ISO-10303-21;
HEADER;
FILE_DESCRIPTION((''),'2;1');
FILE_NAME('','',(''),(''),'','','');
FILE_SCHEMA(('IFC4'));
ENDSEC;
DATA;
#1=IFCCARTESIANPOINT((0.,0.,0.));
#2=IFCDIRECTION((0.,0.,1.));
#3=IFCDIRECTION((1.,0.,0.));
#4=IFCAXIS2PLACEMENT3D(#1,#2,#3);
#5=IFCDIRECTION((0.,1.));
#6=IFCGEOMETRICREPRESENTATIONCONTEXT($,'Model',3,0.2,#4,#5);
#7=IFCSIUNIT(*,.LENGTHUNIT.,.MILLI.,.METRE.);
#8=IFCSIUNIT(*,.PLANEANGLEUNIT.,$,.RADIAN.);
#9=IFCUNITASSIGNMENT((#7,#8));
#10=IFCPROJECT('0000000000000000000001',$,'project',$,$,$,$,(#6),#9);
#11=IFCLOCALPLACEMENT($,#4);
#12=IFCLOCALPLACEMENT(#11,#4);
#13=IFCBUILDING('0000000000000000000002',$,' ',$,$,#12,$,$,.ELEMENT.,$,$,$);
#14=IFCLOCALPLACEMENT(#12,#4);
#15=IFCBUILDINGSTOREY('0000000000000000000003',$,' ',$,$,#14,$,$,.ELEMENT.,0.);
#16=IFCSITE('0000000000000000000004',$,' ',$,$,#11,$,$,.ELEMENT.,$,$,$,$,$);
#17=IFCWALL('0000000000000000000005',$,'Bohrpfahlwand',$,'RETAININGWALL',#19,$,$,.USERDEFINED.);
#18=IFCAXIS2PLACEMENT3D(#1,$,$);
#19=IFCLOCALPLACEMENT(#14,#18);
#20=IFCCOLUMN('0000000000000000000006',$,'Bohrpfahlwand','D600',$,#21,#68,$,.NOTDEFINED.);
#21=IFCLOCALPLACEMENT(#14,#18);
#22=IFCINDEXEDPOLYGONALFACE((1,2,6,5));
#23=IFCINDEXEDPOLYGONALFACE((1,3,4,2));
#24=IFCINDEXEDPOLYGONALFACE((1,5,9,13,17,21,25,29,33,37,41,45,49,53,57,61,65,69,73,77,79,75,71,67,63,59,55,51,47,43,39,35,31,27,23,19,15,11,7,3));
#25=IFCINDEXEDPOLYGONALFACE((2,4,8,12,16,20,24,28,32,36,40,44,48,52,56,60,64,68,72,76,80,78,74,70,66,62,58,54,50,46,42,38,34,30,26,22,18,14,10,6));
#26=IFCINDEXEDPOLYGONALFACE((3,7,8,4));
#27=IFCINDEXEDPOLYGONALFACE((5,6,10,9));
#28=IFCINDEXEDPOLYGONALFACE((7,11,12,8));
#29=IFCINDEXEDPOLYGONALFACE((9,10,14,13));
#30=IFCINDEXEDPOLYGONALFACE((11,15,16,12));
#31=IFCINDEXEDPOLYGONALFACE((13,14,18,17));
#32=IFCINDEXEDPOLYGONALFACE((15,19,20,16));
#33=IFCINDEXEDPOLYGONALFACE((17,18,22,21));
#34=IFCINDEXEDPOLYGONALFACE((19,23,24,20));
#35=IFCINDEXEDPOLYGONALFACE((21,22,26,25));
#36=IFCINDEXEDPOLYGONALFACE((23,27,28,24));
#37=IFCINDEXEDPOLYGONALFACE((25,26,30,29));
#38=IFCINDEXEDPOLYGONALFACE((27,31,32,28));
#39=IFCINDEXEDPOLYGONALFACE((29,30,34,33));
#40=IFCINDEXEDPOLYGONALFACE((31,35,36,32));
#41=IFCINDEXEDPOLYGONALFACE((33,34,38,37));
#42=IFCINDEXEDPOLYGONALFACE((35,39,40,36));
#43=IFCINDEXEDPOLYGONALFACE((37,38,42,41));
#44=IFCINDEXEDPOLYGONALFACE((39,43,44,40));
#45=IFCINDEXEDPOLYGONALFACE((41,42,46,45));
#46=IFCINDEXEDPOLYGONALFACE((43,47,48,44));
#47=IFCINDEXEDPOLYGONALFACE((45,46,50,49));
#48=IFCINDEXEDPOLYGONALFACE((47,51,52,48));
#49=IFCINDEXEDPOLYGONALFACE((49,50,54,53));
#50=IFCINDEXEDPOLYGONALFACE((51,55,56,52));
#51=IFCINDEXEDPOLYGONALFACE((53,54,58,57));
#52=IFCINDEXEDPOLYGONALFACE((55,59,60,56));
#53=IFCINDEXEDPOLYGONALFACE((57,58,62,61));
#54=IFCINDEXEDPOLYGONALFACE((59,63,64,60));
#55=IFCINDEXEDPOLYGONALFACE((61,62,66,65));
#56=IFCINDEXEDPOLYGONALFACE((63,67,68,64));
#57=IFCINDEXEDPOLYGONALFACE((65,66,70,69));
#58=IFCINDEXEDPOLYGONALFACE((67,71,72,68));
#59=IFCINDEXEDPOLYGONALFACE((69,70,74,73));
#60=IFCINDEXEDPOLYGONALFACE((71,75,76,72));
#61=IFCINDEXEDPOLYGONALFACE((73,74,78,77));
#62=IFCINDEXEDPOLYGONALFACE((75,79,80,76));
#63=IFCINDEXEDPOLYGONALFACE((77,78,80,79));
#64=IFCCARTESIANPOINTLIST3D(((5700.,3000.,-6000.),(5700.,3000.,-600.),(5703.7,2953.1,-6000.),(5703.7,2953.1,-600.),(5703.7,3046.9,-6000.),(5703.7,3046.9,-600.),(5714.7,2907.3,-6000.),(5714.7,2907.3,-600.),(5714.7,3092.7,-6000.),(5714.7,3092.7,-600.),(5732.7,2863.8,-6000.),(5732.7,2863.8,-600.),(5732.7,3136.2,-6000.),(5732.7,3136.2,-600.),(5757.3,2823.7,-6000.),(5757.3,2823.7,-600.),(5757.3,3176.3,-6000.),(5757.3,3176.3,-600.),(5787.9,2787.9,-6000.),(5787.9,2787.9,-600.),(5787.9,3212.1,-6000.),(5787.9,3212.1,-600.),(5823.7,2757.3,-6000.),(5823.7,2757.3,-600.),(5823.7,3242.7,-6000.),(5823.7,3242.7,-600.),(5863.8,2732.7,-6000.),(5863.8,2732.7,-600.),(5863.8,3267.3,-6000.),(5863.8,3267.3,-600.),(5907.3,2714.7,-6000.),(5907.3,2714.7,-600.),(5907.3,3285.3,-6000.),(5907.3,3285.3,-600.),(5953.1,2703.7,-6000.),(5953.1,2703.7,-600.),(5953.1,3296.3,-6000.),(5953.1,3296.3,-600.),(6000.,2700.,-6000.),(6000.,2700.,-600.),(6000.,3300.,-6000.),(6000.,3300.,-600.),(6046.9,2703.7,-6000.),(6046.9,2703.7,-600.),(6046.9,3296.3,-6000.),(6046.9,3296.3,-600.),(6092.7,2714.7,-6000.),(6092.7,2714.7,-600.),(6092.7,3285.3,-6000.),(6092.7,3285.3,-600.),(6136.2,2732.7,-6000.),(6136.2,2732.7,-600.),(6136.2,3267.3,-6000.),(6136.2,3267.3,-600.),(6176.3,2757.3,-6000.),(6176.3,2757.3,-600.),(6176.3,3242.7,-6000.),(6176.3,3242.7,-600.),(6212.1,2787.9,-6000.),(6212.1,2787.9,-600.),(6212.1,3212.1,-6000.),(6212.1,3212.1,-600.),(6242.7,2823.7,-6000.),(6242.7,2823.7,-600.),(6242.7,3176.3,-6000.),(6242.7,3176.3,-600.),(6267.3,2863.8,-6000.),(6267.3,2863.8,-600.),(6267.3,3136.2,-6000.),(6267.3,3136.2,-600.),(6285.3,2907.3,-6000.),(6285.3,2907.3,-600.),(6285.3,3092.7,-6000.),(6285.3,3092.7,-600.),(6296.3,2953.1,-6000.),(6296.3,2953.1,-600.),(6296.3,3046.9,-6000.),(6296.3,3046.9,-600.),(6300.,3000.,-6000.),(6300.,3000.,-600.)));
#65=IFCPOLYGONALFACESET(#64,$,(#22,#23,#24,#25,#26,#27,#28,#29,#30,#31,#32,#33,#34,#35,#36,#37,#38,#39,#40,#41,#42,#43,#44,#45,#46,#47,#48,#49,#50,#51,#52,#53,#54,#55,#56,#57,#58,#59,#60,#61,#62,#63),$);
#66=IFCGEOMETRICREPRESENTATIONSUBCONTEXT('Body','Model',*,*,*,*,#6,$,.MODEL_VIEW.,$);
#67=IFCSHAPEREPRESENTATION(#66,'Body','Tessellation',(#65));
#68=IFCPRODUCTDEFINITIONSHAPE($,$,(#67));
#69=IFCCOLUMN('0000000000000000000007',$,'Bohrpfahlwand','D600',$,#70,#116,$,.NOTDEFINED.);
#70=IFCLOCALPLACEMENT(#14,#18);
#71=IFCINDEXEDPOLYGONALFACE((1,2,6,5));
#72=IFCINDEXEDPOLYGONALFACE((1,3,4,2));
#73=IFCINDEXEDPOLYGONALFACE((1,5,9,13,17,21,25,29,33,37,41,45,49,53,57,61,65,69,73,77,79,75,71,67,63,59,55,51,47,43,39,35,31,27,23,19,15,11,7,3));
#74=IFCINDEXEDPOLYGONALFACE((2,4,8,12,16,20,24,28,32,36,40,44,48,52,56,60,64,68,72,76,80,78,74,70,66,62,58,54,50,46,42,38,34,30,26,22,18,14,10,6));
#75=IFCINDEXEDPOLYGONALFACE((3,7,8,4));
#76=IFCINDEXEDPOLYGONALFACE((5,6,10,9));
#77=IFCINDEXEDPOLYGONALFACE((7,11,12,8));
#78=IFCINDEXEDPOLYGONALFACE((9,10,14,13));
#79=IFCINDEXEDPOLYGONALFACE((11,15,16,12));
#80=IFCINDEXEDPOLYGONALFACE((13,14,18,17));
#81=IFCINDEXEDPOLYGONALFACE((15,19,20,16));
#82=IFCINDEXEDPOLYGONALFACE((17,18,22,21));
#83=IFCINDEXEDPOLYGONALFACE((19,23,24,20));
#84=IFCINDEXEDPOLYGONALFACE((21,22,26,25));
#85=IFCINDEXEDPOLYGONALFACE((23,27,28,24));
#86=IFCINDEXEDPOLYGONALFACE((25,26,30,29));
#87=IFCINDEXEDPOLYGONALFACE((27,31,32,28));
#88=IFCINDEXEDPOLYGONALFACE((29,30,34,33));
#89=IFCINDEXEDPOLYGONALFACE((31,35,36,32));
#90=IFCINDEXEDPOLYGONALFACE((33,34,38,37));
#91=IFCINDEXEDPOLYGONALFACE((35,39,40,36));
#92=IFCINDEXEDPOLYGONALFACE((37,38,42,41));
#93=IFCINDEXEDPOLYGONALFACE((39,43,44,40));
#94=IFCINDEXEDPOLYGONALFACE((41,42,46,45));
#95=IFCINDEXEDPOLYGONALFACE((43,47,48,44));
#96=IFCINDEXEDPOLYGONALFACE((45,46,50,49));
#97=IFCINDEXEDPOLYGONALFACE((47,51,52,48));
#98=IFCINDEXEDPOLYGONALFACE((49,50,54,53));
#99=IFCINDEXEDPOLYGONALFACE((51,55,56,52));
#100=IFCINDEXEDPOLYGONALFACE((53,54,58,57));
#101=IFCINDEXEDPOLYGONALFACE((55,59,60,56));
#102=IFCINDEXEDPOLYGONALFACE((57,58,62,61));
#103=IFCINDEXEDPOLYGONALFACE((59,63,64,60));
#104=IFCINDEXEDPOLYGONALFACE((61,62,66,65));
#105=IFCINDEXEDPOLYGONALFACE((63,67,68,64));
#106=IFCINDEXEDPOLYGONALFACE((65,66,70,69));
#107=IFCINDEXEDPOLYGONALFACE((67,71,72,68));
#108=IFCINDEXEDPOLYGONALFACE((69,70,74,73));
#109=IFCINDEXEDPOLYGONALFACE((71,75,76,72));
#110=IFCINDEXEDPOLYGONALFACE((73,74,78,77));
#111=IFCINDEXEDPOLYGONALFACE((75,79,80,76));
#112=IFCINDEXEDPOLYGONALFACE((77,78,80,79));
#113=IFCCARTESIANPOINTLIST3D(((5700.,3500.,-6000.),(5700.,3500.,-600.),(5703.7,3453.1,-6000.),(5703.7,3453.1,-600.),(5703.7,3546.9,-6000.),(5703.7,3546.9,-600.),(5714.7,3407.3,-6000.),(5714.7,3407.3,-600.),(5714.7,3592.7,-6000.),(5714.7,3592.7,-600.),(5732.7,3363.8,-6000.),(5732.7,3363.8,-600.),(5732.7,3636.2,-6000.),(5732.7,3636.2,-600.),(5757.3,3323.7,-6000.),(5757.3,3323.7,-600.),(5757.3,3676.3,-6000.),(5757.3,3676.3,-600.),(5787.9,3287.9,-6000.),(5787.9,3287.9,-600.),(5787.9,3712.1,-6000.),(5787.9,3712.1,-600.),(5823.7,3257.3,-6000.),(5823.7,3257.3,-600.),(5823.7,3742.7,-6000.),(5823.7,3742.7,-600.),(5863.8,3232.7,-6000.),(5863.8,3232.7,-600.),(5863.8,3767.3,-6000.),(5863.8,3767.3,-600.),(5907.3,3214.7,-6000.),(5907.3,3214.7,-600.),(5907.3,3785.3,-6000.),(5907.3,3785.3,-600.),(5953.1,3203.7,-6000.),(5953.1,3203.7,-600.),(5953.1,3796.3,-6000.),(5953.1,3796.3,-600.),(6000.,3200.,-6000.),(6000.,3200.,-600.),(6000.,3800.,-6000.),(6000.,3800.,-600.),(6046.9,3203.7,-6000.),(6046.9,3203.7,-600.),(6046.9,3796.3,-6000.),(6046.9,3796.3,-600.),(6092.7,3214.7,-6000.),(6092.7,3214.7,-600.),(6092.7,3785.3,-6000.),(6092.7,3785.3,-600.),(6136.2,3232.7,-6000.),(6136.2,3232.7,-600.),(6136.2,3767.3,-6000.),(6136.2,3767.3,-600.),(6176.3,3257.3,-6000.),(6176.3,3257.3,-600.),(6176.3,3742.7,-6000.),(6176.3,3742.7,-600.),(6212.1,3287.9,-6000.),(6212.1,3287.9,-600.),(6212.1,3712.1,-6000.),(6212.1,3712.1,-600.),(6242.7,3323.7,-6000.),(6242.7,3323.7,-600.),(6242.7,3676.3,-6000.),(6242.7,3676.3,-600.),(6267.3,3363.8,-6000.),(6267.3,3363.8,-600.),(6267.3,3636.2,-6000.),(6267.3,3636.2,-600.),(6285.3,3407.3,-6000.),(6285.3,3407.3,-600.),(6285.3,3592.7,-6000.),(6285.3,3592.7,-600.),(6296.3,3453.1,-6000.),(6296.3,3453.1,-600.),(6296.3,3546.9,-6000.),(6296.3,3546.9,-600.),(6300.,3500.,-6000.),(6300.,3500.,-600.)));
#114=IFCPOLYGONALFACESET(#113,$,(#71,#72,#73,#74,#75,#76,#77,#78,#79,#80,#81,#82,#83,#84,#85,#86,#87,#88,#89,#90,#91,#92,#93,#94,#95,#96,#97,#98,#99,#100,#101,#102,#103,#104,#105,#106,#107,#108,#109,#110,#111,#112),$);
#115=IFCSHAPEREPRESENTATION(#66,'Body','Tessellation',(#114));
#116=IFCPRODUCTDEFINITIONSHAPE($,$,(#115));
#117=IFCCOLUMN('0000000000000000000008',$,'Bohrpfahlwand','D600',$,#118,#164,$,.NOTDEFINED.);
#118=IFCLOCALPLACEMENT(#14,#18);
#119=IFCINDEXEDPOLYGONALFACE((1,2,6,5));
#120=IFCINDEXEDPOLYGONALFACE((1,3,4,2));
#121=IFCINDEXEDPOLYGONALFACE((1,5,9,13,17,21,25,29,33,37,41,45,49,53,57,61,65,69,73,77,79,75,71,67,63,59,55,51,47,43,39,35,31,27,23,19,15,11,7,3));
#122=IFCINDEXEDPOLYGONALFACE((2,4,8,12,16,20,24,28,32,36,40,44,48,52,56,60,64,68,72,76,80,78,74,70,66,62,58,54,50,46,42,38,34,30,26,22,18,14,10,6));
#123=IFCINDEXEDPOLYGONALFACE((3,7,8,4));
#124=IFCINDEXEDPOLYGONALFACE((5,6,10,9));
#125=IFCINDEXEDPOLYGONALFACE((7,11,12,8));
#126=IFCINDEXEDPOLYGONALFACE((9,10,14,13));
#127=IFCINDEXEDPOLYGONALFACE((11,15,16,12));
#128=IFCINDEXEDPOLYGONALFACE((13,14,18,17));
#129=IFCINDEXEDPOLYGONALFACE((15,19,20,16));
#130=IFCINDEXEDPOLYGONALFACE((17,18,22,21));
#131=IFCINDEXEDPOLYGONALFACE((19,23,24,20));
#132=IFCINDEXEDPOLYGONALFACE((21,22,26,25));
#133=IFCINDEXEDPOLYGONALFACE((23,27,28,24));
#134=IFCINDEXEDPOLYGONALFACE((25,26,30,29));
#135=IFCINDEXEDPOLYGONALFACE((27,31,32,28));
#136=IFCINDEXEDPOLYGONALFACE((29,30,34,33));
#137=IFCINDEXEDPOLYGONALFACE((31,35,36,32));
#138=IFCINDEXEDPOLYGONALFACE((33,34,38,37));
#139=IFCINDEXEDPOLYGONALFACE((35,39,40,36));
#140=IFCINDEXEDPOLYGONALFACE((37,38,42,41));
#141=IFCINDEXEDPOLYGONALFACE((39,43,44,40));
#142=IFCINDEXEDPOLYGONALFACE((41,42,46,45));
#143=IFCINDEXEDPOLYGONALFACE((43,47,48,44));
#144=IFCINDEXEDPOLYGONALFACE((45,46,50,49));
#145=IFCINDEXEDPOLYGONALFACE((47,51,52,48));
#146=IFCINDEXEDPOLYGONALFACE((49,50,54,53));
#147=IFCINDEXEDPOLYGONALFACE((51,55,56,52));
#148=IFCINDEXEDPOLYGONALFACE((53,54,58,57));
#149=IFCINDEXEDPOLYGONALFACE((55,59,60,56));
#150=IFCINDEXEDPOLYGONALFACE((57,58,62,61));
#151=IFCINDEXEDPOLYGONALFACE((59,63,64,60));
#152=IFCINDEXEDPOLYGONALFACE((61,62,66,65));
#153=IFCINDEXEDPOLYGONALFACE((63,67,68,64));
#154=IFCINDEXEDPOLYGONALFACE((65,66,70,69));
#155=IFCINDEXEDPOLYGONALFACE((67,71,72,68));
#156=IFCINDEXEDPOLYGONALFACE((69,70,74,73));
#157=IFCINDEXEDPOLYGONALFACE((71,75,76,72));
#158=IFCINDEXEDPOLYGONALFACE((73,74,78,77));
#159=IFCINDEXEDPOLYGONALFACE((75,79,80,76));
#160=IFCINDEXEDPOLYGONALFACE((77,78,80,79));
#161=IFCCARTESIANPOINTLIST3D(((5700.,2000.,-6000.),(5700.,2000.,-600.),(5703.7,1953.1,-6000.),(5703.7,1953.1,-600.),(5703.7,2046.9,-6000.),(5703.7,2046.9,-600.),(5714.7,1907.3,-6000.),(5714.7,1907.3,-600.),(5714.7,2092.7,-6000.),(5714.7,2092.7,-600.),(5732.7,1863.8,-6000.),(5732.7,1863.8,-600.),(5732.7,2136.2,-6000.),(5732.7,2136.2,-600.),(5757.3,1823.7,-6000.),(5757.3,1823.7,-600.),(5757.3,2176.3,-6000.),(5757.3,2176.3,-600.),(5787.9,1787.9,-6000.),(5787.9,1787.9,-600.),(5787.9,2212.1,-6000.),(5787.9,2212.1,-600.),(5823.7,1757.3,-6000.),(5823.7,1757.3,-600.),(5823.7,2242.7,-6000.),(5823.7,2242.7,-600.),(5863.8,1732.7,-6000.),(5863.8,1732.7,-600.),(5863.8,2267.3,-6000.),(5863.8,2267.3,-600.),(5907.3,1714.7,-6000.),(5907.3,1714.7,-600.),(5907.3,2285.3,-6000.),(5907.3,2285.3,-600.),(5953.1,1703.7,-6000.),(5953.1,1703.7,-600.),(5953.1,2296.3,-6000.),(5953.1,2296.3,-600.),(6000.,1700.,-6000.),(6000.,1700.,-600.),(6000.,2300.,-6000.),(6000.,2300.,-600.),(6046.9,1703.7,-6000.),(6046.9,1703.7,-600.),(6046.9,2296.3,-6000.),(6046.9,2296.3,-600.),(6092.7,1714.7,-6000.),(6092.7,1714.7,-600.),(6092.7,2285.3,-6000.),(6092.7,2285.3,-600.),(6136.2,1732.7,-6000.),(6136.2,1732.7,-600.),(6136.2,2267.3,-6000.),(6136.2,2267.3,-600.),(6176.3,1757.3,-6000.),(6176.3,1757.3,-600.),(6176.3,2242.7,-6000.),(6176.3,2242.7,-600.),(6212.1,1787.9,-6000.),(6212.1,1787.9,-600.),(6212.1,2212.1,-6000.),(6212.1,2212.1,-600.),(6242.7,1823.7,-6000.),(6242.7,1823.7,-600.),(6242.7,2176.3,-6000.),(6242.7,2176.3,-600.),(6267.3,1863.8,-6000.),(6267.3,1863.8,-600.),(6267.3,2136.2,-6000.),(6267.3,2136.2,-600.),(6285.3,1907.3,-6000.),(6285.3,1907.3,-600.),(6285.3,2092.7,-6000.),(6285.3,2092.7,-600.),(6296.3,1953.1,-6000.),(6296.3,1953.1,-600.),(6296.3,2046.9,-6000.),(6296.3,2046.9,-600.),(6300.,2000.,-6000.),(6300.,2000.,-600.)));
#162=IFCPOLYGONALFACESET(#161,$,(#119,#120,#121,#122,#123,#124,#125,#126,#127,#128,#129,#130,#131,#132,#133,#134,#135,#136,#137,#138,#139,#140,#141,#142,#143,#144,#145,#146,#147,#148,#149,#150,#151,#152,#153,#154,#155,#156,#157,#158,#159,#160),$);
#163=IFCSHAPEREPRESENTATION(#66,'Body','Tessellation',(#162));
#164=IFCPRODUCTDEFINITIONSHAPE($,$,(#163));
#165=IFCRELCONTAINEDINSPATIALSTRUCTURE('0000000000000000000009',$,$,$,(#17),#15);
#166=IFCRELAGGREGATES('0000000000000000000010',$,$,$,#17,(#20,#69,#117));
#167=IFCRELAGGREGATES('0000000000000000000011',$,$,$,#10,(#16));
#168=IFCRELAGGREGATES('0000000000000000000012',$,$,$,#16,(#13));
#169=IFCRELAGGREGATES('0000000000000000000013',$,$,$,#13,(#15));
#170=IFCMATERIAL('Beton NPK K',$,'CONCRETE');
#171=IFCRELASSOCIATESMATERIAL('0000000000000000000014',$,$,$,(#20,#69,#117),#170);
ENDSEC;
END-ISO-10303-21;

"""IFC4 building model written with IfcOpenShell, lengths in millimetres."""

from ifc_helpers import new_model, si_unit, direction, frame, origin_with_axes, place, context, subcontext, project, spatial, line, indexed_curve, outline, extrude, material, element, aggregate, save


model = new_model("IFC4")

# Units and contexts
model_context = context("Model", 3, precision=0.2, world=origin_with_axes(), true_north=direction((0.0, 1.0)))
body_context = subcontext(model_context, "Body", "Model", "MODEL_VIEW")
ifc_project = project(units=[si_unit("LENGTHUNIT", "METRE", prefix="MILLI"), si_unit("PLANEANGLEUNIT", "RADIAN")], contexts=[model_context])

# Site, building, storey
site_placement = place(None, origin_with_axes())
site = spatial("IfcSite", under=ifc_project, at=site_placement, Name=" ", CompositionType="ELEMENT")
building_placement = place(site_placement, origin_with_axes())
building = spatial("IfcBuilding", under=site, at=building_placement, Name=" ", CompositionType="ELEMENT")
storey_placement = place(building_placement, origin_with_axes())
storey = spatial("IfcBuildingStorey", under=building, at=storey_placement, Name=" ", CompositionType="ELEMENT", Elevation=0.0)

# Wall, columns
wall_1_placement = place(storey_placement, frame((6000.0, 5000.0, -6000.0), z_axis=(-1.0, 0.0, 0.0), x_axis=(0.0, 0.0, 1.0)))
wall_1 = element("IfcWall", 1, at=wall_1_placement, inside=storey, Name="Bohrpfahlwand", ObjectType="RETAININGWALL", PredefinedType="USERDEFINED")
ifc_material_1 = material(Name="Beton NPK K", Category="CONCRETE")
column_1_placement = place(wall_1_placement, frame((0.0, -2000.0, 0.0), z_axis=(0.0, 0.0, 1.0), x_axis=(1.0, 0.0, 0.0)))
column_1 = element("IfcColumn", 2, at=column_1_placement, material=ifc_material_1, Name="Bohrpfahlwand", Description="D600", PredefinedType="NOTDEFINED", context=body_context, shape_type="SolidModel", body=[
    extrude(outline(indexed_curve([(300.0, 0.0), (296.3, 46.9), (285.3, 92.7), (267.3, 136.2), (242.7, 176.3), (212.1, 212.1), (176.3, 242.7), (136.2, 267.3), (92.7, 285.3), (46.9, 296.3), (0.0, 300.0), (-46.9, 296.3), (-92.7, 285.3), (-136.2, 267.3), (-176.3, 242.7), (-212.1, 212.1), (-242.7, 176.3), (-267.3, 136.2), (-285.3, 92.7), (-296.3, 46.9), (-300.0, 0.0), (-296.3, -46.9), (-285.3, -92.7), (-267.3, -136.2), (-242.7, -176.3), (-212.1, -212.1), (-176.3, -242.7), (-136.2, -267.3), (-92.7, -285.3), (-46.9, -296.3), (0.0, -300.0), (46.9, -296.3), (92.7, -285.3), (136.2, -267.3), (176.3, -242.7), (212.1, -212.1), (242.7, -176.3), (267.3, -136.2), (285.3, -92.7), (296.3, -46.9)], segments=[line(1, 2, 3, 4, 5, 6, 7, 8, 9, 10, 11, 12, 13, 14, 15, 16, 17, 18, 19, 20, 21, 22, 23, 24, 25, 26, 27, 28, 29, 30, 31, 32, 33, 34, 35, 36, 37, 38, 39, 40, 1)])), frame((0.0, 0.0, 0.0), z_axis=(-1.0, 0.0, 0.0), x_axis=(0.0, 0.0, 1.0)), (0.0, 0.0, -1.0), 5400.0),
])
column_2_placement = place(wall_1_placement, frame((0.0, -1500.0, 0.0), z_axis=(0.0, 0.0, 1.0), x_axis=(1.0, 0.0, 0.0)))
column_2 = element("IfcColumn", 3, at=column_2_placement, material=ifc_material_1, Name="Bohrpfahlwand", Description="D600", PredefinedType="NOTDEFINED", context=body_context, shape_type="SolidModel", body=[
    extrude(outline(indexed_curve([(300.0, 0.0), (296.3, 46.9), (285.3, 92.7), (267.3, 136.2), (242.7, 176.3), (212.1, 212.1), (176.3, 242.7), (136.2, 267.3), (92.7, 285.3), (46.9, 296.3), (0.0, 300.0), (-46.9, 296.3), (-92.7, 285.3), (-136.2, 267.3), (-176.3, 242.7), (-212.1, 212.1), (-242.7, 176.3), (-267.3, 136.2), (-285.3, 92.7), (-296.3, 46.9), (-300.0, 0.0), (-296.3, -46.9), (-285.3, -92.7), (-267.3, -136.2), (-242.7, -176.3), (-212.1, -212.1), (-176.3, -242.7), (-136.2, -267.3), (-92.7, -285.3), (-46.9, -296.3), (0.0, -300.0), (46.9, -296.3), (92.7, -285.3), (136.2, -267.3), (176.3, -242.7), (212.1, -212.1), (242.7, -176.3), (267.3, -136.2), (285.3, -92.7), (296.3, -46.9)], segments=[line(1, 2, 3, 4, 5, 6, 7, 8, 9, 10, 11, 12, 13, 14, 15, 16, 17, 18, 19, 20, 21, 22, 23, 24, 25, 26, 27, 28, 29, 30, 31, 32, 33, 34, 35, 36, 37, 38, 39, 40, 1)])), frame((0.0, 0.0, 0.0), z_axis=(-1.0, 0.0, 0.0), x_axis=(0.0, 0.0, 1.0)), (0.0, 0.0, -1.0), 5400.0),
])
column_3_placement = place(wall_1_placement, frame((0.0, -3000.0, 0.0), z_axis=(0.0, 0.0, 1.0), x_axis=(1.0, 0.0, 0.0)))
column_3 = element("IfcColumn", 4, at=column_3_placement, material=ifc_material_1, Name="Bohrpfahlwand", Description="D600", PredefinedType="NOTDEFINED", context=body_context, shape_type="SolidModel", body=[
    extrude(outline(indexed_curve([(300.0, 0.0), (296.3, 46.9), (285.3, 92.7), (267.3, 136.2), (242.7, 176.3), (212.1, 212.1), (176.3, 242.7), (136.2, 267.3), (92.7, 285.3), (46.9, 296.3), (0.0, 300.0), (-46.9, 296.3), (-92.7, 285.3), (-136.2, 267.3), (-176.3, 242.7), (-212.1, 212.1), (-242.7, 176.3), (-267.3, 136.2), (-285.3, 92.7), (-296.3, 46.9), (-300.0, 0.0), (-296.3, -46.9), (-285.3, -92.7), (-267.3, -136.2), (-242.7, -176.3), (-212.1, -212.1), (-176.3, -242.7), (-136.2, -267.3), (-92.7, -285.3), (-46.9, -296.3), (0.0, -300.0), (46.9, -296.3), (92.7, -285.3), (136.2, -267.3), (176.3, -242.7), (212.1, -212.1), (242.7, -176.3), (267.3, -136.2), (285.3, -92.7), (296.3, -46.9)], segments=[line(1, 2, 3, 4, 5, 6, 7, 8, 9, 10, 11, 12, 13, 14, 15, 16, 17, 18, 19, 20, 21, 22, 23, 24, 25, 26, 27, 28, 29, 30, 31, 32, 33, 34, 35, 36, 37, 38, 39, 40, 1)])), frame((0.0, 0.0, 0.0), z_axis=(-1.0, 0.0, 0.0), x_axis=(0.0, 0.0, 1.0)), (0.0, 0.0, -1.0), 5400.0),
])
aggregate(wall_1, [column_1, column_2, column_3])

save(model, "model.ifc")
